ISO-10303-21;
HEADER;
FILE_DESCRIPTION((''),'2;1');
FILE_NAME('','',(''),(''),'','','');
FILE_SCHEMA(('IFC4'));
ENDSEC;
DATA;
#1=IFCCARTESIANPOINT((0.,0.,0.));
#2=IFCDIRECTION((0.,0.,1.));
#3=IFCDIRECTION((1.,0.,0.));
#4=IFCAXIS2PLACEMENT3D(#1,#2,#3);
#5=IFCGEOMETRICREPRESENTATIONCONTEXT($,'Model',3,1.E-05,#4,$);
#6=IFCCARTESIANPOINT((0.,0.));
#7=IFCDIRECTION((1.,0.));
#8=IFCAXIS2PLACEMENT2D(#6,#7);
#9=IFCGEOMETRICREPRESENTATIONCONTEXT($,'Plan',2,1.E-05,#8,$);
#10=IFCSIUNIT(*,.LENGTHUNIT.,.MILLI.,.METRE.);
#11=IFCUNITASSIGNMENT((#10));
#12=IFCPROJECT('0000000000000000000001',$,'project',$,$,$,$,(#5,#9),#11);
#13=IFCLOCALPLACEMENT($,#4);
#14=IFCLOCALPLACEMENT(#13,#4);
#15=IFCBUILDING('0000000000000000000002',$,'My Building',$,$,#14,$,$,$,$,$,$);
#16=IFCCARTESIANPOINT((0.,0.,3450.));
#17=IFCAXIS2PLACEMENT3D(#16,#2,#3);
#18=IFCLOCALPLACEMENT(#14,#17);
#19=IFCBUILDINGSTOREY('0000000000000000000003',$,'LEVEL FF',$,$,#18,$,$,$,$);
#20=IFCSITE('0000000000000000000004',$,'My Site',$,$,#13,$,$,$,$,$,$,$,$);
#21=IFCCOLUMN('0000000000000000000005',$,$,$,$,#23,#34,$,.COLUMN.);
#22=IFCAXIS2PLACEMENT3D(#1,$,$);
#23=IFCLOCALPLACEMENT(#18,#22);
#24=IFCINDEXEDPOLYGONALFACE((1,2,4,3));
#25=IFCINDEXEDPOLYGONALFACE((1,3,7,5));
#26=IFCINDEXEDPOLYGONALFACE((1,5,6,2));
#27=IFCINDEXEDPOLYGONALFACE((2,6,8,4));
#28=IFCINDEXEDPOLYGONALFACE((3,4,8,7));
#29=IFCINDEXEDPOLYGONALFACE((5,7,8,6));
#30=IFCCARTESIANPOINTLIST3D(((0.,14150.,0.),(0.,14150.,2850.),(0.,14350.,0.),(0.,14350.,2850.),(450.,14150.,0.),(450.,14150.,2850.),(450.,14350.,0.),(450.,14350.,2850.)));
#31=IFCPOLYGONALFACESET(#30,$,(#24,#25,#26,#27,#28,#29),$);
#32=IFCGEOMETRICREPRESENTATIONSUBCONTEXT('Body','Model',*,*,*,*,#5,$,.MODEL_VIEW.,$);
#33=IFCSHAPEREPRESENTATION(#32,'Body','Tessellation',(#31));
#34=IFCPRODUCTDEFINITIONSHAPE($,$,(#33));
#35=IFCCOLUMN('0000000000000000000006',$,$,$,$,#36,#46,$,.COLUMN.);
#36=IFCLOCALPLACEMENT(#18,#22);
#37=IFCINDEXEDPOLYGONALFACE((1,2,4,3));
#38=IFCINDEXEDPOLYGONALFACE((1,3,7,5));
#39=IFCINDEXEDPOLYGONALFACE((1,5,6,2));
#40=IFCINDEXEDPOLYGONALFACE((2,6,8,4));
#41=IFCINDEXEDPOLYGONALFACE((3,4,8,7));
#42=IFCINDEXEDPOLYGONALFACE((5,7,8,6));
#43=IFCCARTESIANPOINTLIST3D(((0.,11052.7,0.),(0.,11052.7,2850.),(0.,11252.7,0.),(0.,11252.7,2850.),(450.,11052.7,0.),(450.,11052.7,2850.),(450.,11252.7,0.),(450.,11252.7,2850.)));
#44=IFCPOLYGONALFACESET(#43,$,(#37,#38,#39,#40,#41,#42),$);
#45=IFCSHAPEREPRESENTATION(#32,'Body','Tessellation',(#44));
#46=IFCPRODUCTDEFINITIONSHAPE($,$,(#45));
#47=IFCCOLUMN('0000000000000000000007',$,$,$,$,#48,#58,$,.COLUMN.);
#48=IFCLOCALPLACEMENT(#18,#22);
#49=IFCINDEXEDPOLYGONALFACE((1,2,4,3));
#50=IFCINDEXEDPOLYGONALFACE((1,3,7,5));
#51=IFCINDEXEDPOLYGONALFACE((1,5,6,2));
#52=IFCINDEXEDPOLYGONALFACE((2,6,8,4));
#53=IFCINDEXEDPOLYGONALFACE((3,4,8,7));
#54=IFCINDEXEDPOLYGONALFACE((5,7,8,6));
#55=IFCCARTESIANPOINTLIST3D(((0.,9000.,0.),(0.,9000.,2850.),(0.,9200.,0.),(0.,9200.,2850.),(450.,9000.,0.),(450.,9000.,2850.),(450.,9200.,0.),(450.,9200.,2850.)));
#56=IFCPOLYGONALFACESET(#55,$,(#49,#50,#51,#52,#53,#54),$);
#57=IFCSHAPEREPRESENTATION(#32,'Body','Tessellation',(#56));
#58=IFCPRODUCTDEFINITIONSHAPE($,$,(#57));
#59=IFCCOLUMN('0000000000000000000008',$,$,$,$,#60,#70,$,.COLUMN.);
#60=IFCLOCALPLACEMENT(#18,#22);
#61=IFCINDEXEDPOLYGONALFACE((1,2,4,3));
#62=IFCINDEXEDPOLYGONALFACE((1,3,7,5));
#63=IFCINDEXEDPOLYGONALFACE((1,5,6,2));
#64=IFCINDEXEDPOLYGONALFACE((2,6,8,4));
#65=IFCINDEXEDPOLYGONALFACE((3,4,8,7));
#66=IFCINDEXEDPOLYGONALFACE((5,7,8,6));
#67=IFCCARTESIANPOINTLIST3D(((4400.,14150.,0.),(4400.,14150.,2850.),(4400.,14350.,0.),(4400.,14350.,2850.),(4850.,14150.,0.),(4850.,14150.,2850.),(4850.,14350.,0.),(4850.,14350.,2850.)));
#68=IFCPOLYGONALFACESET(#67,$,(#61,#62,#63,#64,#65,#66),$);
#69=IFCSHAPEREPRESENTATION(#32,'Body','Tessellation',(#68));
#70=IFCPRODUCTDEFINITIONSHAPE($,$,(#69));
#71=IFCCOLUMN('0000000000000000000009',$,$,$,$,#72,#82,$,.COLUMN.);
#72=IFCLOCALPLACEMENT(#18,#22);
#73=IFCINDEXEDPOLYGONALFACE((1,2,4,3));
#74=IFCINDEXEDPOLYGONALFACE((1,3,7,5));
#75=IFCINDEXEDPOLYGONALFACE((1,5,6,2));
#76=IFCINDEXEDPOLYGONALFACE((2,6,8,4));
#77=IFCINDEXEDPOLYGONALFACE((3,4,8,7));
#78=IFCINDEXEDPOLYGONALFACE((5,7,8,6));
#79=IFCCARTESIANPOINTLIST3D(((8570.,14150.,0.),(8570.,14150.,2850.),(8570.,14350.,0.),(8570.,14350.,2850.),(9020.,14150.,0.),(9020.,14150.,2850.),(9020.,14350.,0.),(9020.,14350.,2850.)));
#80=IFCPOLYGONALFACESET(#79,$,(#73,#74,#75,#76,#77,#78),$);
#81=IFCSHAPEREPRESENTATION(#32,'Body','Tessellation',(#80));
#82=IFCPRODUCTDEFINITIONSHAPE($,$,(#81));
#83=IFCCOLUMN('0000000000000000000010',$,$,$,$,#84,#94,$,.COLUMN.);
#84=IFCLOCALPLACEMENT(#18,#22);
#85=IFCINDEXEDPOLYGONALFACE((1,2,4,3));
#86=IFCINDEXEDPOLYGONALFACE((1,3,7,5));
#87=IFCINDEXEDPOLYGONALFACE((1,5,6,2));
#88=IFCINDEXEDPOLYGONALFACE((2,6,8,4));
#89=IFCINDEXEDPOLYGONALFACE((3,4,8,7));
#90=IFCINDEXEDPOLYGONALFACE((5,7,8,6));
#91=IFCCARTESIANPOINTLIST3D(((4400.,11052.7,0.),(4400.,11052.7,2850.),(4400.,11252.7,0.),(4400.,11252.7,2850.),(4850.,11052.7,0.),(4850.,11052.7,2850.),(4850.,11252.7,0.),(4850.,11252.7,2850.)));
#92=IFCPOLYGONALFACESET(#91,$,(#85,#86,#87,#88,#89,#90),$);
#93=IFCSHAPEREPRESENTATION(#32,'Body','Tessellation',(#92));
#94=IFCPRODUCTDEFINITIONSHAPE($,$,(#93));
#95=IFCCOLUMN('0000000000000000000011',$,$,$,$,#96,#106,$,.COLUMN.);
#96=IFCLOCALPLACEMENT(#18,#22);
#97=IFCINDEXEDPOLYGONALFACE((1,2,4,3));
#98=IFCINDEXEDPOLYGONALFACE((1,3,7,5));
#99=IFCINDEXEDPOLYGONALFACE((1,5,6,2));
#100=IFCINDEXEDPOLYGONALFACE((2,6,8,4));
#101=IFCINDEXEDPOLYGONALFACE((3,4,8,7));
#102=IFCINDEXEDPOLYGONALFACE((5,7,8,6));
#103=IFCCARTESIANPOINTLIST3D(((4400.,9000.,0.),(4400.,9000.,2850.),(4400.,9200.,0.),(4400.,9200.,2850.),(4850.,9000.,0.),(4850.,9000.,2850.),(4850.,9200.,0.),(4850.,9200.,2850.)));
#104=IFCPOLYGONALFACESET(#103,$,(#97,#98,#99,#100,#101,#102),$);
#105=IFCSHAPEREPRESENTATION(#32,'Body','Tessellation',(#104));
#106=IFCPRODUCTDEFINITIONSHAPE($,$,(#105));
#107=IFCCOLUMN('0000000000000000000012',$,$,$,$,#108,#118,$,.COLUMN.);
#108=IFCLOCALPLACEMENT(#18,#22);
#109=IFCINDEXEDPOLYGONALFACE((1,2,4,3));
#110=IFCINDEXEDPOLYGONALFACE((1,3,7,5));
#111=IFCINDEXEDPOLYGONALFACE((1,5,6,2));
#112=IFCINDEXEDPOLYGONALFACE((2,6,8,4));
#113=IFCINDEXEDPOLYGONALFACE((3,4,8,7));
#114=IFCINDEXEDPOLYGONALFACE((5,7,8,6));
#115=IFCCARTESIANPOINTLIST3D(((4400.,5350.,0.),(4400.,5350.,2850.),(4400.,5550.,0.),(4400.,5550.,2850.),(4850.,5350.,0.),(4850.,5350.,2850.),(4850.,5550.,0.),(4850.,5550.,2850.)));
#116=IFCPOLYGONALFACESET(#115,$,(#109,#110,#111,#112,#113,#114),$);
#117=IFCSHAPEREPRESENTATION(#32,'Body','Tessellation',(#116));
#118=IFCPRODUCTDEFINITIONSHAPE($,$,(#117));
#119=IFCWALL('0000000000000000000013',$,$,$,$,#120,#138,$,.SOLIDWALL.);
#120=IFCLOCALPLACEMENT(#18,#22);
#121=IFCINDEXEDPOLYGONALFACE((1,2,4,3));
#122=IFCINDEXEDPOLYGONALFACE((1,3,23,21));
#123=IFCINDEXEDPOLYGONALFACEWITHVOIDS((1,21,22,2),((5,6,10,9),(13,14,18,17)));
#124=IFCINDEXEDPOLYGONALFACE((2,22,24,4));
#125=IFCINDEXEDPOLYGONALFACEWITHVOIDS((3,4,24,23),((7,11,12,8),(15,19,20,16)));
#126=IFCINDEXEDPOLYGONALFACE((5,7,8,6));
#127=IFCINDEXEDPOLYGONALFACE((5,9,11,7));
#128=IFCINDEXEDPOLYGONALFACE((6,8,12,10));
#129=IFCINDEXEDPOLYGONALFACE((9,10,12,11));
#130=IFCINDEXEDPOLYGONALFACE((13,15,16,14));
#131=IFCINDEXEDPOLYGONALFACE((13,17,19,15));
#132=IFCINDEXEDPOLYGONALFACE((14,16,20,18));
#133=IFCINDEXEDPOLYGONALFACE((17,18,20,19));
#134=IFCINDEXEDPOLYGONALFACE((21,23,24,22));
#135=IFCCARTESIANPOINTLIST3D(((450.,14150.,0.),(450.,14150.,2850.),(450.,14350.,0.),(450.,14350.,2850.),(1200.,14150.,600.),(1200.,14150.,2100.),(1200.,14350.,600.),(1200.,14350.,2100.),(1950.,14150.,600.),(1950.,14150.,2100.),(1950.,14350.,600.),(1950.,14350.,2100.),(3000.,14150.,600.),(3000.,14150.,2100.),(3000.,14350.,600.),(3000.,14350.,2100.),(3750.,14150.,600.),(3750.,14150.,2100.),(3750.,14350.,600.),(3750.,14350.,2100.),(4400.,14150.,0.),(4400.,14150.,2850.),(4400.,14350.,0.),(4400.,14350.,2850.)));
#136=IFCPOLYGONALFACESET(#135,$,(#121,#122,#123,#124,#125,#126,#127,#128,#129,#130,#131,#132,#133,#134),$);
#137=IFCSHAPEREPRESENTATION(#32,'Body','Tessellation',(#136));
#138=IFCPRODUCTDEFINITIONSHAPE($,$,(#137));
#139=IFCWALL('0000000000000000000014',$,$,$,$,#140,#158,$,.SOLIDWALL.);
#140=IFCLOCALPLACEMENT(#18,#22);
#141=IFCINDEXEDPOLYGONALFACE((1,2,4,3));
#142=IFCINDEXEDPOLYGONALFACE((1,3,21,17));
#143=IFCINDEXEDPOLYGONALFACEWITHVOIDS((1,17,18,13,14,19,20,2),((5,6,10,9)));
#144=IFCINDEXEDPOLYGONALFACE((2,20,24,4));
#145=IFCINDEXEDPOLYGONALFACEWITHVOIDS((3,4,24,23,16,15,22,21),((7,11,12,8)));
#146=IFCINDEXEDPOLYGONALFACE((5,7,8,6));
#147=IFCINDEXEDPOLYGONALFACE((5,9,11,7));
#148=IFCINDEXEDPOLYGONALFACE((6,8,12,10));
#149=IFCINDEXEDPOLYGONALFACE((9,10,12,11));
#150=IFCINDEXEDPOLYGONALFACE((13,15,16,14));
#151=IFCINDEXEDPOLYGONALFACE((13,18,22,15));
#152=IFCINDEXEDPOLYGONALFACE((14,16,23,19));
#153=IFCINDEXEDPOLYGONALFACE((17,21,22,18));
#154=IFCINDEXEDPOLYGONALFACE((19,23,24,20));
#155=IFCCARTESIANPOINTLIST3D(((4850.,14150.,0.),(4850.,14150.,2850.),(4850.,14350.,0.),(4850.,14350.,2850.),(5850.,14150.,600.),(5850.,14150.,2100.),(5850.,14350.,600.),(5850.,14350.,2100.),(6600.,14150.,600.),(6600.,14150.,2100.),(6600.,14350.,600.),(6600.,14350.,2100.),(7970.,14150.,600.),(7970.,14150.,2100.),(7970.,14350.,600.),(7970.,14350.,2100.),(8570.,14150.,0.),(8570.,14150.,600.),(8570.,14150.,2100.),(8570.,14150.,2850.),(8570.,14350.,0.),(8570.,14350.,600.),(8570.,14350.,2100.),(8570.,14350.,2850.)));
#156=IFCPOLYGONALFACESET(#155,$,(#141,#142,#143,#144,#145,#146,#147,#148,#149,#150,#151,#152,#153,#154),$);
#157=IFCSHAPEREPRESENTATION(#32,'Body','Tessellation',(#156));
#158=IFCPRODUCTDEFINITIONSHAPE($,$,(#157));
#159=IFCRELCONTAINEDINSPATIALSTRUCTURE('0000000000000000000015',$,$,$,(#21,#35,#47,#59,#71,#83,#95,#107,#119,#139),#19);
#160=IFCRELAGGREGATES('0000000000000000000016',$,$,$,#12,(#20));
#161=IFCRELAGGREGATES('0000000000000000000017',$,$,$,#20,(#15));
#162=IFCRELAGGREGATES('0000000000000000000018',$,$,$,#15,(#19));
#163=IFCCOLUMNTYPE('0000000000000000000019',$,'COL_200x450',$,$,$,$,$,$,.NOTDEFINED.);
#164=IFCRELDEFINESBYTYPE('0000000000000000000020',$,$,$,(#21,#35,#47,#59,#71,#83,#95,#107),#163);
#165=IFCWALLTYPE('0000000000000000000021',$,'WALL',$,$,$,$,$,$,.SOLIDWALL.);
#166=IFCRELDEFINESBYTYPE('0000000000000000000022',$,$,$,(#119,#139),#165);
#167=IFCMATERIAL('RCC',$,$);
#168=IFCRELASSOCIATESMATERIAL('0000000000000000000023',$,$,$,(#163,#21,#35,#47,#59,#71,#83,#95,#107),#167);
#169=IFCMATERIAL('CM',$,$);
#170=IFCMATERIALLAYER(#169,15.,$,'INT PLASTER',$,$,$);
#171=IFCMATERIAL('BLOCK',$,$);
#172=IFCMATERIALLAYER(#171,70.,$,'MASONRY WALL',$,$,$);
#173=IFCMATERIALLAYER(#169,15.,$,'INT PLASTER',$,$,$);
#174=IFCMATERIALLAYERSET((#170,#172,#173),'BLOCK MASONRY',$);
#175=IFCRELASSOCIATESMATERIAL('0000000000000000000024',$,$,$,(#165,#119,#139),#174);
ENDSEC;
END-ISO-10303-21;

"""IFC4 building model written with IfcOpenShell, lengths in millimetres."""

from ifc_helpers import new_model, si_unit, frame, origin_with_axes, origin_2d_with_axis, place, context, subcontext, project, spatial, indexed_curve, rectangle, outline, extrude, material, layer, layer_set, layer_usage, material_profile, profile_set, profile_usage, type_object, element, save


model = new_model("IFC4")

# Units and contexts
model_context = context("Model", 3, precision=1e-05, world=origin_with_axes())
plan_context = context("Plan", 2, precision=1e-05, world=origin_2d_with_axis())
body_context = subcontext(model_context, "Body", "Model", "MODEL_VIEW")
ifc_project = project(units=[si_unit("LENGTHUNIT", "METRE", prefix="MILLI")], contexts=[model_context, plan_context])

# Site, building, storey
site_placement = place(None, origin_with_axes())
site = spatial("IfcSite", under=ifc_project, at=site_placement, Name="My Site")
building_placement = place(site_placement, origin_with_axes())
building = spatial("IfcBuilding", under=site, at=building_placement, Name="My Building")
storey_placement = place(building_placement, frame((0.0, 0.0, 3450.0), z_axis=(0.0, 0.0, 1.0), x_axis=(1.0, 0.0, 0.0)))
storey = spatial("IfcBuildingStorey", under=building, at=storey_placement, Name="LEVEL FF")

# Columns
ifc_material_1 = material(Name="RCC")
ifc_material_profile = material_profile(ifc_material_1, rectangle(XDim=200.0, YDim=450.0))
ifc_profile_set = profile_set([ifc_material_profile], Name="COL_200x450")
ifc_profile_usage_1 = profile_usage(ifc_profile_set)
column_type = type_object("IfcColumnType", Name="COL_200x450", PredefinedType="NOTDEFINED", material=ifc_profile_set)
column_1_placement = place(storey_placement, frame((225.0, 14250.0, 0.0), z_axis=(0.0, 0.0, 1.0), x_axis=(0.0, -1.0, 0.0)))
element("IfcColumn", 1, at=column_1_placement, inside=storey, type_object=column_type, material=ifc_profile_usage_1, PredefinedType="COLUMN", context=body_context, shape_type="SweptSolid", body=[
    extrude(rectangle(XDim=200.0, YDim=450.0), origin_with_axes(), (0.0, 0.0, 1.0), 2850.0),
])
ifc_profile_usage_2 = profile_usage(ifc_profile_set)
column_2_placement = place(storey_placement, frame((225.0, 11152.7, 0.0), z_axis=(0.0, 0.0, 1.0), x_axis=(0.0, -1.0, 0.0)))
element("IfcColumn", 2, at=column_2_placement, inside=storey, type_object=column_type, material=ifc_profile_usage_2, PredefinedType="COLUMN", context=body_context, shape_type="SweptSolid", body=[
    extrude(rectangle(XDim=200.0, YDim=450.0), origin_with_axes(), (0.0, 0.0, 1.0), 2850.0),
])
ifc_profile_usage_3 = profile_usage(ifc_profile_set)
column_3_placement = place(storey_placement, frame((225.0, 9100.0, 0.0), z_axis=(0.0, 0.0, 1.0), x_axis=(0.0, -1.0, 0.0)))
element("IfcColumn", 3, at=column_3_placement, inside=storey, type_object=column_type, material=ifc_profile_usage_3, PredefinedType="COLUMN", context=body_context, shape_type="SweptSolid", body=[
    extrude(rectangle(XDim=200.0, YDim=450.0), origin_with_axes(), (0.0, 0.0, 1.0), 2850.0),
])
ifc_profile_usage_4 = profile_usage(ifc_profile_set)
column_4_placement = place(storey_placement, frame((4625.0, 14250.0, 0.0), z_axis=(0.0, 0.0, 1.0), x_axis=(0.0, -1.0, 0.0)))
element("IfcColumn", 4, at=column_4_placement, inside=storey, type_object=column_type, material=ifc_profile_usage_4, PredefinedType="COLUMN", context=body_context, shape_type="SweptSolid", body=[
    extrude(rectangle(XDim=200.0, YDim=450.0), origin_with_axes(), (0.0, 0.0, 1.0), 2850.0),
])
ifc_profile_usage_5 = profile_usage(ifc_profile_set)
column_5_placement = place(storey_placement, frame((8795.0, 14250.0, 0.0), z_axis=(0.0, 0.0, 1.0), x_axis=(0.0, -1.0, 0.0)))
element("IfcColumn", 5, at=column_5_placement, inside=storey, type_object=column_type, material=ifc_profile_usage_5, PredefinedType="COLUMN", context=body_context, shape_type="SweptSolid", body=[
    extrude(rectangle(XDim=200.0, YDim=450.0), origin_with_axes(), (0.0, 0.0, 1.0), 2850.0),
])
ifc_profile_usage_6 = profile_usage(ifc_profile_set)
column_6_placement = place(storey_placement, frame((4625.0, 11152.7, 0.0), z_axis=(0.0, 0.0, 1.0), x_axis=(0.0, -1.0, 0.0)))
element("IfcColumn", 6, at=column_6_placement, inside=storey, type_object=column_type, material=ifc_profile_usage_6, PredefinedType="COLUMN", context=body_context, shape_type="SweptSolid", body=[
    extrude(rectangle(XDim=200.0, YDim=450.0), origin_with_axes(), (0.0, 0.0, 1.0), 2850.0),
])
ifc_profile_usage_7 = profile_usage(ifc_profile_set)
column_7_placement = place(storey_placement, frame((4625.0, 9100.0, 0.0), z_axis=(0.0, 0.0, 1.0), x_axis=(0.0, -1.0, 0.0)))
element("IfcColumn", 7, at=column_7_placement, inside=storey, type_object=column_type, material=ifc_profile_usage_7, PredefinedType="COLUMN", context=body_context, shape_type="SweptSolid", body=[
    extrude(rectangle(XDim=200.0, YDim=450.0), origin_with_axes(), (0.0, 0.0, 1.0), 2850.0),
])
ifc_profile_usage_8 = profile_usage(ifc_profile_set)
column_8_placement = place(storey_placement, frame((4625.0, 5450.0, 0.0), z_axis=(0.0, 0.0, 1.0), x_axis=(0.0, -1.0, 0.0)))
element("IfcColumn", 8, at=column_8_placement, inside=storey, type_object=column_type, material=ifc_profile_usage_8, PredefinedType="COLUMN", context=body_context, shape_type="SweptSolid", body=[
    extrude(rectangle(XDim=200.0, YDim=450.0), origin_with_axes(), (0.0, 0.0, 1.0), 2850.0),
])

# Walls, openings
ifc_material_2 = material(Name="CM")
ifc_layer_1 = layer(ifc_material_2, 15.0, Name="INT PLASTER")
ifc_material_3 = material(Name="BLOCK")
ifc_layer_2 = layer(ifc_material_3, 70.0, Name="MASONRY WALL")
ifc_layer_3 = layer(ifc_material_2, 15.0, Name="INT PLASTER")
ifc_layer_set = layer_set([ifc_layer_1, ifc_layer_2, ifc_layer_3], Name="BLOCK MASONRY")
ifc_layer_usage_1 = layer_usage(ifc_layer_set, "AXIS2", "POSITIVE", 0.0)
wall_type = type_object("IfcWallType", Name="WALL", PredefinedType="SOLIDWALL", material=ifc_layer_set)
wall_1_placement = place(storey_placement, frame((450.0, 14350.0, 0.0), z_axis=(0.0, 0.0, 1.0), x_axis=(0.0, -1.0, 0.0)))
wall_1 = element("IfcWall", 9, at=wall_1_placement, inside=storey, type_object=wall_type, material=ifc_layer_usage_1, PredefinedType="SOLIDWALL", context=body_context, shape_type="SweptSolid", body=[
    extrude(outline(indexed_curve([(0.0, 0.0), (0.0, 3950.0), (200.0, 3950.0), (200.0, 0.0), (0.0, 0.0)], self_intersect=False)), origin_with_axes(), (0.0, 0.0, 1.0), 2850.0),
])
opening_1_placement = place(wall_1_placement, frame((200.0, 2550.0, 600.0), z_axis=(0.0, 0.0, 1.0), x_axis=(0.0, 1.0, 0.0)))
element("IfcOpeningElement", 10, at=opening_1_placement, cuts=wall_1, PredefinedType="OPENING", context=body_context, shape_type="SweptSolid", body=[
    extrude(outline(indexed_curve([(0.0, 0.0), (0.0, 400.0), (750.0, 400.0), (750.0, 0.0), (0.0, 0.0)], self_intersect=False)), frame((0.0, -100.0, 0.0), z_axis=(0.0, 0.0, 1.0), x_axis=(1.0, 0.0, 0.0)), (0.0, 0.0, 1.0), 1500.0),
])
opening_2_placement = place(wall_1_placement, frame((200.0, 750.0, 600.0), z_axis=(0.0, 0.0, 1.0), x_axis=(0.0, 1.0, 0.0)))
element("IfcOpeningElement", 11, at=opening_2_placement, cuts=wall_1, PredefinedType="OPENING", context=body_context, shape_type="SweptSolid", body=[
    extrude(outline(indexed_curve([(0.0, 0.0), (0.0, 400.0), (750.0, 400.0), (750.0, 0.0), (0.0, 0.0)], self_intersect=False)), frame((0.0, -100.0, 0.0), z_axis=(0.0, 0.0, 1.0), x_axis=(1.0, 0.0, 0.0)), (0.0, 0.0, 1.0), 1500.0),
])
ifc_layer_usage_2 = layer_usage(ifc_layer_set, "AXIS2", "POSITIVE", 0.0)
wall_2_placement = place(storey_placement, frame((4850.0, 14350.0, 0.0), z_axis=(0.0, 0.0, 1.0), x_axis=(0.0, -1.0, 0.0)))
wall_2 = element("IfcWall", 12, at=wall_2_placement, inside=storey, type_object=wall_type, material=ifc_layer_usage_2, PredefinedType="SOLIDWALL", context=body_context, shape_type="SweptSolid", body=[
    extrude(outline(indexed_curve([(0.0, 0.0), (0.0, 3720.0), (200.0, 3720.0), (200.0, 0.0), (0.0, 0.0)], self_intersect=False)), origin_with_axes(), (0.0, 0.0, 1.0), 2850.0),
])
opening_3_placement = place(wall_2_placement, frame((200.0, 1000.0, 600.0), z_axis=(0.0, 0.0, 1.0), x_axis=(0.0, 1.0, 0.0)))
element("IfcOpeningElement", 13, at=opening_3_placement, cuts=wall_2, PredefinedType="OPENING", context=body_context, shape_type="SweptSolid", body=[
    extrude(outline(indexed_curve([(0.0, 0.0), (0.0, 400.0), (750.0, 400.0), (750.0, 0.0), (0.0, 0.0)], self_intersect=False)), frame((0.0, -100.0, 0.0), z_axis=(0.0, 0.0, 1.0), x_axis=(1.0, 0.0, 0.0)), (0.0, 0.0, 1.0), 1500.0),
])
opening_4_placement = place(wall_2_placement, frame((200.0, 3120.0, 600.0), z_axis=(0.0, 0.0, 1.0), x_axis=(0.0, 1.0, 0.0)))
element("IfcOpeningElement", 14, at=opening_4_placement, cuts=wall_2, PredefinedType="OPENING", context=body_context, shape_type="SweptSolid", body=[
    extrude(outline(indexed_curve([(0.0, 0.0), (0.0, 400.0), (750.0, 400.0), (750.0, 0.0), (0.0, 0.0)], self_intersect=False)), frame((0.0, -100.0, 0.0), z_axis=(0.0, 0.0, 1.0), x_axis=(1.0, 0.0, 0.0)), (0.0, 0.0, 1.0), 1500.0),
])

save(model, "model.ifc")
